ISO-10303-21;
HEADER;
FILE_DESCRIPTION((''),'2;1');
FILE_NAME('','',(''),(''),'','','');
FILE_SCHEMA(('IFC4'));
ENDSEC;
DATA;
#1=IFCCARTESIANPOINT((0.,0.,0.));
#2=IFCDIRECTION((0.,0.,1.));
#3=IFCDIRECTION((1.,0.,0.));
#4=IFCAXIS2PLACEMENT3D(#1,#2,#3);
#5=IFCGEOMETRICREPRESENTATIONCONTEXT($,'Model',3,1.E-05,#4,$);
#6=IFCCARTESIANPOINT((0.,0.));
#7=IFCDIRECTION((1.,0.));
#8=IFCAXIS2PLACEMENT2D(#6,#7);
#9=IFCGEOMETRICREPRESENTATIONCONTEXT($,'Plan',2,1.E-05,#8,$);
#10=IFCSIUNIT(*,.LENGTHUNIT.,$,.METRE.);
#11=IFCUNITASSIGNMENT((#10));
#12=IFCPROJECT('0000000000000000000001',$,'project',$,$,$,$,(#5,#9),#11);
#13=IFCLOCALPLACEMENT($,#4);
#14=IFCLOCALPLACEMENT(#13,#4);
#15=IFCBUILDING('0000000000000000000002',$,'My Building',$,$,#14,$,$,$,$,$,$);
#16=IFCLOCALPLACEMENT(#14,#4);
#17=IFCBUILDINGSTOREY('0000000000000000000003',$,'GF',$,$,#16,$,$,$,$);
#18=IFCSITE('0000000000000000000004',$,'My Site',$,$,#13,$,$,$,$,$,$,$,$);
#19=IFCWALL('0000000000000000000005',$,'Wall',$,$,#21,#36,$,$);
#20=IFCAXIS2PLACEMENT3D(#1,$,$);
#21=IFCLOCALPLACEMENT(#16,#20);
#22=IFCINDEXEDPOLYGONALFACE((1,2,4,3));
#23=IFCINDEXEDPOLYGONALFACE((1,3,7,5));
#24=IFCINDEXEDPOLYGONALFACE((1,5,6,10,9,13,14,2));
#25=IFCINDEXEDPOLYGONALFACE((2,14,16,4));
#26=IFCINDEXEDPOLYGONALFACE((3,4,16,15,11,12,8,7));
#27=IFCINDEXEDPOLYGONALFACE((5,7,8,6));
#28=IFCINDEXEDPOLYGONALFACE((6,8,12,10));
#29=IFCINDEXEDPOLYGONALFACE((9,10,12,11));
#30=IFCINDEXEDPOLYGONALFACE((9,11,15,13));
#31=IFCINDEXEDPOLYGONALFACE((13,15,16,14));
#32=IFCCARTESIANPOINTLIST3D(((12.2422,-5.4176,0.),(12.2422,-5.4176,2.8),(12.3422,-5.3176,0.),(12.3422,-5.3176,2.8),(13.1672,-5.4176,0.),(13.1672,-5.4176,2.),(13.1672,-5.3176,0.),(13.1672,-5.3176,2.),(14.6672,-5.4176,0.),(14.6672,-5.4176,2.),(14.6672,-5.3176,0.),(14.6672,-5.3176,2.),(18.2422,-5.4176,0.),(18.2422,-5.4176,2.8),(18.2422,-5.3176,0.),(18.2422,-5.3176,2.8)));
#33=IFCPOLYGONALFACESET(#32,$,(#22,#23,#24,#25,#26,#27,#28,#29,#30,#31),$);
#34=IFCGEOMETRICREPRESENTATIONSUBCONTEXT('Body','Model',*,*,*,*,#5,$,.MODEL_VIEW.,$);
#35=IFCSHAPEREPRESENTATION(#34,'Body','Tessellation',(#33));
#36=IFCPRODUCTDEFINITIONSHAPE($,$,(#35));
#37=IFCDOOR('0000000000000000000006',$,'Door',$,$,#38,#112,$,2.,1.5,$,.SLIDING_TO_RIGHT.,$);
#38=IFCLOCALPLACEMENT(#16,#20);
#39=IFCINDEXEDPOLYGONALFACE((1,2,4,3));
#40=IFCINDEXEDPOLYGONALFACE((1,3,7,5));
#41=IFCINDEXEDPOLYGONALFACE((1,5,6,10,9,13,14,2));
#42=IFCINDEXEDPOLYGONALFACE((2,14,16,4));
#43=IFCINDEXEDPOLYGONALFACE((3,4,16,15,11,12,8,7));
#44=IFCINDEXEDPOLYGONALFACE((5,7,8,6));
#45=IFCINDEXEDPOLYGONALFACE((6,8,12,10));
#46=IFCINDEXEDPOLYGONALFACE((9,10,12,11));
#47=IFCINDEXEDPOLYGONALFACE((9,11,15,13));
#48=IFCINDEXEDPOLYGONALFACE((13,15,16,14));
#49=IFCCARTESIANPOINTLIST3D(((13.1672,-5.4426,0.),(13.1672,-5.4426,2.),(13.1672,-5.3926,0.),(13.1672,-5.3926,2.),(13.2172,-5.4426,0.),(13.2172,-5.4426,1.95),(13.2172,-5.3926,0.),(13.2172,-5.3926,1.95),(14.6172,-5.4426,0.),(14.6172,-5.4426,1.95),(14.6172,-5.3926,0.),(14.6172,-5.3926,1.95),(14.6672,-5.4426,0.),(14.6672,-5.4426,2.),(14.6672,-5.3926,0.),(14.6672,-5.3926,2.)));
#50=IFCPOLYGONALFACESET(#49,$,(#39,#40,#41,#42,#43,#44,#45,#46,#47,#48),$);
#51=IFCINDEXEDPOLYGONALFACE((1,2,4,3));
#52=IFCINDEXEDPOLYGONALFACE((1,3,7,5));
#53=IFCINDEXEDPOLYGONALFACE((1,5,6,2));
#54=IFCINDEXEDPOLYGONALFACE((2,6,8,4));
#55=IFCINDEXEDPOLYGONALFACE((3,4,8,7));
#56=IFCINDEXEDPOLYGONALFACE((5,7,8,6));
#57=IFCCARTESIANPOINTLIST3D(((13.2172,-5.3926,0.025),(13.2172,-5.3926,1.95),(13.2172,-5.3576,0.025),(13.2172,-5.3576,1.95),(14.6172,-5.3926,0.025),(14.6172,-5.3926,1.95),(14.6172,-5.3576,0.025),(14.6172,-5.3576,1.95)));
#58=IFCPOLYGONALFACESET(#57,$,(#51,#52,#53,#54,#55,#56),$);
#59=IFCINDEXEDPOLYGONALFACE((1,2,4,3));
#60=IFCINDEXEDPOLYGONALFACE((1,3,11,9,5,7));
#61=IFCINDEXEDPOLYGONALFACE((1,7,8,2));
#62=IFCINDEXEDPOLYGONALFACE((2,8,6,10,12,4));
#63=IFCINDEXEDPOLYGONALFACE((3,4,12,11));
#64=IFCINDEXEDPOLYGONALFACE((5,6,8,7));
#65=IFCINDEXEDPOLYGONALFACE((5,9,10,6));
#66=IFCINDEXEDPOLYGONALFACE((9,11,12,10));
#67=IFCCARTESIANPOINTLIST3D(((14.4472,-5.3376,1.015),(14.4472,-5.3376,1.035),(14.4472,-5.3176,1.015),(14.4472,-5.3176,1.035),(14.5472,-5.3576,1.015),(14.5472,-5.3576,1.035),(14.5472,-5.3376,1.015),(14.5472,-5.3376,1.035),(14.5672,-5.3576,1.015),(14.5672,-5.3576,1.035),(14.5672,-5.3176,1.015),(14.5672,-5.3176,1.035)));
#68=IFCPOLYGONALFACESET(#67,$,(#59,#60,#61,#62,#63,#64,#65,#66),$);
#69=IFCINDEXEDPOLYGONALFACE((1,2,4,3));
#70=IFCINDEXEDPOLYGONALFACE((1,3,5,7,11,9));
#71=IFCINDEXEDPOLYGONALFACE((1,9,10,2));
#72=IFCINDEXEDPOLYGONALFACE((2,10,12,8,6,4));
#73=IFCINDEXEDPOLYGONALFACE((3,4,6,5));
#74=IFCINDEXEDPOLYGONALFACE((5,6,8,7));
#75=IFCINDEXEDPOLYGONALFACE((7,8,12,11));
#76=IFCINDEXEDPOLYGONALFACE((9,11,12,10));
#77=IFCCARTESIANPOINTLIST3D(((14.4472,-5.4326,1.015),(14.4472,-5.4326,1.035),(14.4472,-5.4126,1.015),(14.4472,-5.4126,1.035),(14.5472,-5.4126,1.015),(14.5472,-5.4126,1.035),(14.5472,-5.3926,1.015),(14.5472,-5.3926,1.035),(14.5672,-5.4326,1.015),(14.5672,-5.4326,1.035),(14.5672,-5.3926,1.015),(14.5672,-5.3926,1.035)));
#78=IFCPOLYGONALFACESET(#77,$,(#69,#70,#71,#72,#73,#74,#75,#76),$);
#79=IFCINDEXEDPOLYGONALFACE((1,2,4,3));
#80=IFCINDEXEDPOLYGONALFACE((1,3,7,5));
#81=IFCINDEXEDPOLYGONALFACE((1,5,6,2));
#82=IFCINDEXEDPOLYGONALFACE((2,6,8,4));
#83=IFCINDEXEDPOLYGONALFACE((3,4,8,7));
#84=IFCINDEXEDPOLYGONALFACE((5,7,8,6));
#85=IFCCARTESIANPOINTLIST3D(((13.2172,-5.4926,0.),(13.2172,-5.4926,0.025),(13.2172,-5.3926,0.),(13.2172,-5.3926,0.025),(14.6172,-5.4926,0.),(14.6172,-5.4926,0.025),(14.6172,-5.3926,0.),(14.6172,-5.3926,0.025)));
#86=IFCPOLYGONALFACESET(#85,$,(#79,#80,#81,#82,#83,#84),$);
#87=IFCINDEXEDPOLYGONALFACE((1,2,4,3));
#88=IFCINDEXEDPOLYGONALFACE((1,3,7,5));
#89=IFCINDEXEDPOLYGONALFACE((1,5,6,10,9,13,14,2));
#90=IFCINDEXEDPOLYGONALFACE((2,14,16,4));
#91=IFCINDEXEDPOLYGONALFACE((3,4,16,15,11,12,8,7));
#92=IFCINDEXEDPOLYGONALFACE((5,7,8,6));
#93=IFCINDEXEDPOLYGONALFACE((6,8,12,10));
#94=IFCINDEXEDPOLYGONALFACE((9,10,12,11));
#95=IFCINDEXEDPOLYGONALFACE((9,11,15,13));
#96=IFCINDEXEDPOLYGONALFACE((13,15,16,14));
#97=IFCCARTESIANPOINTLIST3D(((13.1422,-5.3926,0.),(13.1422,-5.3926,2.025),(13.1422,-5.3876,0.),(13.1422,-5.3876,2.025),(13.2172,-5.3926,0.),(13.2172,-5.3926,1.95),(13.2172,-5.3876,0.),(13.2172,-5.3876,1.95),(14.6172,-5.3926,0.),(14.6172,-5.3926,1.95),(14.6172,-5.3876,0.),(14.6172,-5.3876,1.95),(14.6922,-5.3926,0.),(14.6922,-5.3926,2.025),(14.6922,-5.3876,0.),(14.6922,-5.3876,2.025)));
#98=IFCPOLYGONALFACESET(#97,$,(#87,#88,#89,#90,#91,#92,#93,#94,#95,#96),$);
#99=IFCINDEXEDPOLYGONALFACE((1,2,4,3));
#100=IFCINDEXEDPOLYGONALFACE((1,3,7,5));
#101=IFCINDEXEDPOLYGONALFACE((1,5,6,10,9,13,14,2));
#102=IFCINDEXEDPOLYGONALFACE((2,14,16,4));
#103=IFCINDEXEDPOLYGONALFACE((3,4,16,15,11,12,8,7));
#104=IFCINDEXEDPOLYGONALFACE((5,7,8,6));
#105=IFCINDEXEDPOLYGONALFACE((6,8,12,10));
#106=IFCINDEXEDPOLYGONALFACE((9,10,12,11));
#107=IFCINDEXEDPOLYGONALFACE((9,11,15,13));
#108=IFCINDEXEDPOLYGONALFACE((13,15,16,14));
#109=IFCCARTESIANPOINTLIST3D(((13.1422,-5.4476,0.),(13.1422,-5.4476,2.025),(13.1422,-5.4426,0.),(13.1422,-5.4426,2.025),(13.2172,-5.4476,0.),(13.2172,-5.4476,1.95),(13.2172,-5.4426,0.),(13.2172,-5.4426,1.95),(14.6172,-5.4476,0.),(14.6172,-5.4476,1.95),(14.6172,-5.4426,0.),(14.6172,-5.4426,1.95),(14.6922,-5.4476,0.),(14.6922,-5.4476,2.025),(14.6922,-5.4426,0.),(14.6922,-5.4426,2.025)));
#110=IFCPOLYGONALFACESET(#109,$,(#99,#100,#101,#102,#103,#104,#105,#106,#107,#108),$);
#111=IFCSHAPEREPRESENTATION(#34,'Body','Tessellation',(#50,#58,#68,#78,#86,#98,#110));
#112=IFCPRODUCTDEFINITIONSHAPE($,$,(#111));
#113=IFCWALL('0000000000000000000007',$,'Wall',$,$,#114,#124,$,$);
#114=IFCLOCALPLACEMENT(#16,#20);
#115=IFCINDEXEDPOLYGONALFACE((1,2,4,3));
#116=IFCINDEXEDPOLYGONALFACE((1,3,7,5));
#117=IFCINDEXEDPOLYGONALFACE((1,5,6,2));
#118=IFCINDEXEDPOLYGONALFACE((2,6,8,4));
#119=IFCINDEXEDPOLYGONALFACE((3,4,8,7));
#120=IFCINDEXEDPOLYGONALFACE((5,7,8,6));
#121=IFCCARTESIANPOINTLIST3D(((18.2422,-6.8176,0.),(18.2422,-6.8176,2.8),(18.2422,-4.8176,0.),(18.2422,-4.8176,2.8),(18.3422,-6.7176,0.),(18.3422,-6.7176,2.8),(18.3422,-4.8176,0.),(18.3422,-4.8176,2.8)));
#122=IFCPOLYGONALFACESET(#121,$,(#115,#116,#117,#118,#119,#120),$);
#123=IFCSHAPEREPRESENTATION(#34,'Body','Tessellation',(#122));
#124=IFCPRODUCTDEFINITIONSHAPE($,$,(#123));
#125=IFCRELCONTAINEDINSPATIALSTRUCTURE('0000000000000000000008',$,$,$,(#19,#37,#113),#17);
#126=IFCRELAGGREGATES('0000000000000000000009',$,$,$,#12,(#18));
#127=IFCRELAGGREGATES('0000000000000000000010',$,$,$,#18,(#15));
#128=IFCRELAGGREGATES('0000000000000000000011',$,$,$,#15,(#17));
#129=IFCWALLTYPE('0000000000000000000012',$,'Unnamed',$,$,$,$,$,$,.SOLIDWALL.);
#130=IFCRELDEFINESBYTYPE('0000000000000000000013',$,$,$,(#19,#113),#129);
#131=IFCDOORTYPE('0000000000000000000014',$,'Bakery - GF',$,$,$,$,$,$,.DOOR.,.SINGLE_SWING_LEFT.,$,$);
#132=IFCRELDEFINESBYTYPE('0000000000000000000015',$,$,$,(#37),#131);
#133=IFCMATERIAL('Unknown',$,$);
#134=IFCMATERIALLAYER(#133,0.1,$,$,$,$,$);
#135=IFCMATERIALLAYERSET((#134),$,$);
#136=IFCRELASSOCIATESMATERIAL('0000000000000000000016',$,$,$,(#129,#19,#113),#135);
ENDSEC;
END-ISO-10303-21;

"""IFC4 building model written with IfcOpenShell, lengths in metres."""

from ifc_helpers import new_model, entity, si_unit, frame, origin_with_axes, origin_2d_with_axis, place, context, subcontext, project, spatial, line, indexed_curve, outline, extrude, shape, source, transform, mapped, material, layer, layer_set, layer_usage, type_object, type_shapes, element, fill, save


model = new_model("IFC4")

# Units and contexts
model_context = context("Model", 3, precision=1e-05, world=origin_with_axes())
plan_context = context("Plan", 2, precision=1e-05, world=origin_2d_with_axis())
body_context_1 = subcontext(model_context, "Body", "Model", "MODEL_VIEW")
body_context_2 = subcontext(plan_context, "Body", "Plan", "PLAN_VIEW")
ifc_project = project(units=[si_unit("LENGTHUNIT", "METRE")], contexts=[model_context, plan_context])

# Site, building, storey
site_placement = place(None, origin_with_axes())
site = spatial("IfcSite", under=ifc_project, at=site_placement, Name="My Site")
building_placement = place(site_placement, origin_with_axes())
building = spatial("IfcBuilding", under=site, at=building_placement, Name="My Building")
storey_placement = place(building_placement, origin_with_axes())
storey = spatial("IfcBuildingStorey", under=building, at=storey_placement, Name="GF")

# Shared definitions
ifc_material = material(Name="Unknown")

# Shared definitions
ifc_layer_1 = layer(ifc_material, 0.1)
ifc_layer_set_1 = layer_set([ifc_layer_1])
wall_type = type_object("IfcWallType", Name="Unnamed", PredefinedType="SOLIDWALL", material=ifc_layer_set_1)

# Wall, opening, door
ifc_layer_usage_1 = layer_usage(ifc_layer_set_1, "AXIS2", "POSITIVE", 0.0)
wall_1_placement = place(storey_placement, frame((18.2422, -5.3176, 0.0), z_axis=(0.0, 0.0, 1.0), x_axis=(-1.0, 0.0, 0.0)))
wall_1 = element("IfcWall", 1, at=wall_1_placement, inside=storey, type_object=wall_type, material=ifc_layer_usage_1, Name="Wall", context=body_context_1, shape_type="SweptSolid", body=[
    extrude(outline(indexed_curve([(0.0, 0.0), (0.0, 0.1), (6.0, 0.1), (5.9, 0.0)], segments=[line(1, 2, 3, 4, 1)])), origin_with_axes(), (0.0, 0.0, 1.0), 2.8),
])
shared_shape_1 = source(origin_with_axes(), body_context_1, "Body", "SweptSolid", [
    extrude(outline(indexed_curve([(0.0, 0.0), (1.5, 0.0), (1.5, 2.0), (0.0, 2.0)], segments=[line(1, 2, 3, 4, 1)])), frame((0.0, -0.6, 0.0), z_axis=(0.0, -1.0, 0.0), x_axis=(1.0, 0.0, 0.0)), (0.0, 0.0, -1.0), 1.2),
])
opening_1_placement = place(wall_1_placement, frame((3.575, 0.075, 0.0), z_axis=(0.0, 0.0, 1.0), x_axis=(1.0, -0.000001, 0.0)))
opening_1 = element("IfcOpeningElement", 2, at=opening_1_placement, cuts=wall_1, PredefinedType="OPENING", context=body_context_1, shape_type="MappedRepresentation", body=[
    mapped(shared_shape_1, transform((0.0, 0.0, 0.0), x_axis=(1.0, 0.0, 0.0), y_axis=(0.0, 1.0, 0.0), z_axis=(0.0, 0.0, 1.0), scale=1.0)),
])
door_type_1 = type_object("IfcDoorType", Name="Bakery - GF", OperationType="SINGLE_SWING_LEFT", PredefinedType="DOOR")
shared_shape_2 = source(origin_with_axes(), body_context_1, "Body", "SweptSolid", [
    extrude(outline(indexed_curve([(0.0, 0.0), (0.0, 2.0), (1.5, 2.0), (1.5, 0.0), (1.45, 0.0), (1.45, 1.95), (0.05, 1.95), (0.05, 0.0)], segments=[line(1, 2, 3, 4, 5, 6, 7, 8, 1)])), frame((0.0, 0.0, 0.0), z_axis=(0.0, -1.0, 0.0), x_axis=(1.0, 0.0, 0.0)), (0.0, 0.0, -1.0), 0.05),
    extrude(outline(indexed_curve([(0.0, 0.0), (1.4, 0.0), (1.4, 0.035), (0.0, 0.035)], segments=[line(1, 2, 3, 4, 1)])), frame((0.05, -0.035, 0.025), z_axis=(0.0, 0.0, 1.0), x_axis=(1.0, 0.0, 0.0)), (0.0, 0.0, 1.0), 1.925),
    extrude(outline(indexed_curve([(0.0, 0.0), (0.0, -0.04), (0.12, -0.04), (0.12, -0.02), (0.02, -0.02), (0.02, 0.0)], segments=[line(1, 2, 3, 4, 5, 6, 1)])), frame((0.1, -0.035, 1.015), z_axis=(0.0, 0.0, 1.0), x_axis=(1.0, 0.0, 0.0)), (0.0, 0.0, 1.0), 0.02),
    extrude(outline(indexed_curve([(0.0, 0.0), (0.0, 0.04), (0.12, 0.04), (0.12, 0.02), (0.02, 0.02), (0.02, 0.0)], segments=[line(1, 2, 3, 4, 5, 6, 1)])), frame((0.1, 0.0, 1.015), z_axis=(0.0, 0.0, 1.0), x_axis=(1.0, 0.0, 0.0)), (0.0, 0.0, 1.0), 0.02),
    extrude(outline(indexed_curve([(0.0, 0.0), (1.4, 0.0), (1.4, 0.1), (0.0, 0.1)], segments=[line(1, 2, 3, 4, 1)])), frame((0.05, 0.0, 0.0), z_axis=(0.0, 0.0, 1.0), x_axis=(1.0, 0.0, 0.0)), (0.0, 0.0, 1.0), 0.025),
    extrude(outline(indexed_curve([(0.0, 0.0), (0.0, 2.025), (1.55, 2.025), (1.55, 0.0), (1.475, 0.0), (1.475, 1.95), (0.075, 1.95), (0.075, 0.0)], segments=[line(1, 2, 3, 4, 5, 6, 7, 8, 1)])), frame((-0.025, -0.005, 0.0), z_axis=(0.0, -1.0, 0.0), x_axis=(1.0, 0.0, 0.0)), (0.0, 0.0, -1.0), 0.005),
    extrude(outline(indexed_curve([(0.0, 0.0), (0.0, 2.025), (1.55, 2.025), (1.55, 0.0), (1.475, 0.0), (1.475, 1.95), (0.075, 1.95), (0.075, 0.0)], segments=[line(1, 2, 3, 4, 5, 6, 7, 8, 1)])), frame((-0.025, 0.05, 0.0), z_axis=(0.0, -1.0, 0.0), x_axis=(1.0, 0.0, 0.0)), (0.0, 0.0, -1.0), 0.005),
])
shared_shape_3 = source(origin_with_axes(), body_context_2, "Body", "Curve2D", [
    entity("IfcIndexedPolyCurve", entity("IfcCartesianPointList2D", [[0.0, 0.0], [0.05, 0.0], [0.05, 0.05], [0.0, 0.05]]), [entity("IfcLineIndex", [1, 2, 3, 4, 1])]),
    entity("IfcIndexedPolyCurve", entity("IfcCartesianPointList2D", [[1.5, 0.0], [1.45, 0.0], [1.45, 0.05], [1.5, 0.05]]), [entity("IfcLineIndex", [1, 2, 3, 4, 1])]),
    entity("IfcIndexedPolyCurve", entity("IfcCartesianPointList2D", [[2.15, -0.035], [0.75, -0.035], [0.75, 0.0], [2.15, 0.0]]), [entity("IfcLineIndex", [1, 2, 3, 4, 1])]),
])
type_shapes(door_type_1, [shared_shape_2, shared_shape_3])
door_1_placement = place(opening_1_placement, frame((0.0, 0.0, 0.0), z_axis=(0.0, 0.0, 1.0), x_axis=(1.0, 0.0, 0.0)))
door_1 = element("IfcDoor", 3, at=door_1_placement, inside=storey, type_object=door_type_1, Name="Door", OperationType="SLIDING_TO_RIGHT", OverallHeight=2.0, OverallWidth=1.5, shapes=[
    shape(body_context_1, "Body", "MappedRepresentation", [mapped(shared_shape_2, transform((0.0, 0.0, 0.0), x_axis=(1.0, 0.0, 0.0), y_axis=(0.0, 1.0, 0.0), z_axis=(0.0, 0.0, 1.0), scale=1.0))]),
    shape(body_context_2, "Body", "MappedRepresentation", [mapped(shared_shape_3, transform((0.0, 0.0, 0.0), x_axis=(1.0, 0.0, 0.0), y_axis=(0.0, 1.0, 0.0), z_axis=(0.0, 0.0, 1.0), scale=1.0))]),
])
fill(opening_1, door_1)

# Wall
ifc_layer_usage_2 = layer_usage(ifc_layer_set_1, "AXIS2", "POSITIVE", 0.0)
wall_2_placement = place(storey_placement, frame((18.2422, -4.8176, 0.0), z_axis=(0.0, 0.0, 1.0), x_axis=(0.0, -1.0, 0.0)))
element("IfcWall", 4, at=wall_2_placement, inside=storey, type_object=wall_type, material=ifc_layer_usage_2, Name="Wall", context=body_context_1, shape_type="SweptSolid", body=[
    extrude(outline(indexed_curve([(0.0, 0.0), (0.0, 0.1), (1.9, 0.1), (2.0, 0.0)], segments=[line(1, 2, 3, 4, 1)])), origin_with_axes(), (0.0, 0.0, 1.0), 2.8),
])

save(model, "model.ifc")
